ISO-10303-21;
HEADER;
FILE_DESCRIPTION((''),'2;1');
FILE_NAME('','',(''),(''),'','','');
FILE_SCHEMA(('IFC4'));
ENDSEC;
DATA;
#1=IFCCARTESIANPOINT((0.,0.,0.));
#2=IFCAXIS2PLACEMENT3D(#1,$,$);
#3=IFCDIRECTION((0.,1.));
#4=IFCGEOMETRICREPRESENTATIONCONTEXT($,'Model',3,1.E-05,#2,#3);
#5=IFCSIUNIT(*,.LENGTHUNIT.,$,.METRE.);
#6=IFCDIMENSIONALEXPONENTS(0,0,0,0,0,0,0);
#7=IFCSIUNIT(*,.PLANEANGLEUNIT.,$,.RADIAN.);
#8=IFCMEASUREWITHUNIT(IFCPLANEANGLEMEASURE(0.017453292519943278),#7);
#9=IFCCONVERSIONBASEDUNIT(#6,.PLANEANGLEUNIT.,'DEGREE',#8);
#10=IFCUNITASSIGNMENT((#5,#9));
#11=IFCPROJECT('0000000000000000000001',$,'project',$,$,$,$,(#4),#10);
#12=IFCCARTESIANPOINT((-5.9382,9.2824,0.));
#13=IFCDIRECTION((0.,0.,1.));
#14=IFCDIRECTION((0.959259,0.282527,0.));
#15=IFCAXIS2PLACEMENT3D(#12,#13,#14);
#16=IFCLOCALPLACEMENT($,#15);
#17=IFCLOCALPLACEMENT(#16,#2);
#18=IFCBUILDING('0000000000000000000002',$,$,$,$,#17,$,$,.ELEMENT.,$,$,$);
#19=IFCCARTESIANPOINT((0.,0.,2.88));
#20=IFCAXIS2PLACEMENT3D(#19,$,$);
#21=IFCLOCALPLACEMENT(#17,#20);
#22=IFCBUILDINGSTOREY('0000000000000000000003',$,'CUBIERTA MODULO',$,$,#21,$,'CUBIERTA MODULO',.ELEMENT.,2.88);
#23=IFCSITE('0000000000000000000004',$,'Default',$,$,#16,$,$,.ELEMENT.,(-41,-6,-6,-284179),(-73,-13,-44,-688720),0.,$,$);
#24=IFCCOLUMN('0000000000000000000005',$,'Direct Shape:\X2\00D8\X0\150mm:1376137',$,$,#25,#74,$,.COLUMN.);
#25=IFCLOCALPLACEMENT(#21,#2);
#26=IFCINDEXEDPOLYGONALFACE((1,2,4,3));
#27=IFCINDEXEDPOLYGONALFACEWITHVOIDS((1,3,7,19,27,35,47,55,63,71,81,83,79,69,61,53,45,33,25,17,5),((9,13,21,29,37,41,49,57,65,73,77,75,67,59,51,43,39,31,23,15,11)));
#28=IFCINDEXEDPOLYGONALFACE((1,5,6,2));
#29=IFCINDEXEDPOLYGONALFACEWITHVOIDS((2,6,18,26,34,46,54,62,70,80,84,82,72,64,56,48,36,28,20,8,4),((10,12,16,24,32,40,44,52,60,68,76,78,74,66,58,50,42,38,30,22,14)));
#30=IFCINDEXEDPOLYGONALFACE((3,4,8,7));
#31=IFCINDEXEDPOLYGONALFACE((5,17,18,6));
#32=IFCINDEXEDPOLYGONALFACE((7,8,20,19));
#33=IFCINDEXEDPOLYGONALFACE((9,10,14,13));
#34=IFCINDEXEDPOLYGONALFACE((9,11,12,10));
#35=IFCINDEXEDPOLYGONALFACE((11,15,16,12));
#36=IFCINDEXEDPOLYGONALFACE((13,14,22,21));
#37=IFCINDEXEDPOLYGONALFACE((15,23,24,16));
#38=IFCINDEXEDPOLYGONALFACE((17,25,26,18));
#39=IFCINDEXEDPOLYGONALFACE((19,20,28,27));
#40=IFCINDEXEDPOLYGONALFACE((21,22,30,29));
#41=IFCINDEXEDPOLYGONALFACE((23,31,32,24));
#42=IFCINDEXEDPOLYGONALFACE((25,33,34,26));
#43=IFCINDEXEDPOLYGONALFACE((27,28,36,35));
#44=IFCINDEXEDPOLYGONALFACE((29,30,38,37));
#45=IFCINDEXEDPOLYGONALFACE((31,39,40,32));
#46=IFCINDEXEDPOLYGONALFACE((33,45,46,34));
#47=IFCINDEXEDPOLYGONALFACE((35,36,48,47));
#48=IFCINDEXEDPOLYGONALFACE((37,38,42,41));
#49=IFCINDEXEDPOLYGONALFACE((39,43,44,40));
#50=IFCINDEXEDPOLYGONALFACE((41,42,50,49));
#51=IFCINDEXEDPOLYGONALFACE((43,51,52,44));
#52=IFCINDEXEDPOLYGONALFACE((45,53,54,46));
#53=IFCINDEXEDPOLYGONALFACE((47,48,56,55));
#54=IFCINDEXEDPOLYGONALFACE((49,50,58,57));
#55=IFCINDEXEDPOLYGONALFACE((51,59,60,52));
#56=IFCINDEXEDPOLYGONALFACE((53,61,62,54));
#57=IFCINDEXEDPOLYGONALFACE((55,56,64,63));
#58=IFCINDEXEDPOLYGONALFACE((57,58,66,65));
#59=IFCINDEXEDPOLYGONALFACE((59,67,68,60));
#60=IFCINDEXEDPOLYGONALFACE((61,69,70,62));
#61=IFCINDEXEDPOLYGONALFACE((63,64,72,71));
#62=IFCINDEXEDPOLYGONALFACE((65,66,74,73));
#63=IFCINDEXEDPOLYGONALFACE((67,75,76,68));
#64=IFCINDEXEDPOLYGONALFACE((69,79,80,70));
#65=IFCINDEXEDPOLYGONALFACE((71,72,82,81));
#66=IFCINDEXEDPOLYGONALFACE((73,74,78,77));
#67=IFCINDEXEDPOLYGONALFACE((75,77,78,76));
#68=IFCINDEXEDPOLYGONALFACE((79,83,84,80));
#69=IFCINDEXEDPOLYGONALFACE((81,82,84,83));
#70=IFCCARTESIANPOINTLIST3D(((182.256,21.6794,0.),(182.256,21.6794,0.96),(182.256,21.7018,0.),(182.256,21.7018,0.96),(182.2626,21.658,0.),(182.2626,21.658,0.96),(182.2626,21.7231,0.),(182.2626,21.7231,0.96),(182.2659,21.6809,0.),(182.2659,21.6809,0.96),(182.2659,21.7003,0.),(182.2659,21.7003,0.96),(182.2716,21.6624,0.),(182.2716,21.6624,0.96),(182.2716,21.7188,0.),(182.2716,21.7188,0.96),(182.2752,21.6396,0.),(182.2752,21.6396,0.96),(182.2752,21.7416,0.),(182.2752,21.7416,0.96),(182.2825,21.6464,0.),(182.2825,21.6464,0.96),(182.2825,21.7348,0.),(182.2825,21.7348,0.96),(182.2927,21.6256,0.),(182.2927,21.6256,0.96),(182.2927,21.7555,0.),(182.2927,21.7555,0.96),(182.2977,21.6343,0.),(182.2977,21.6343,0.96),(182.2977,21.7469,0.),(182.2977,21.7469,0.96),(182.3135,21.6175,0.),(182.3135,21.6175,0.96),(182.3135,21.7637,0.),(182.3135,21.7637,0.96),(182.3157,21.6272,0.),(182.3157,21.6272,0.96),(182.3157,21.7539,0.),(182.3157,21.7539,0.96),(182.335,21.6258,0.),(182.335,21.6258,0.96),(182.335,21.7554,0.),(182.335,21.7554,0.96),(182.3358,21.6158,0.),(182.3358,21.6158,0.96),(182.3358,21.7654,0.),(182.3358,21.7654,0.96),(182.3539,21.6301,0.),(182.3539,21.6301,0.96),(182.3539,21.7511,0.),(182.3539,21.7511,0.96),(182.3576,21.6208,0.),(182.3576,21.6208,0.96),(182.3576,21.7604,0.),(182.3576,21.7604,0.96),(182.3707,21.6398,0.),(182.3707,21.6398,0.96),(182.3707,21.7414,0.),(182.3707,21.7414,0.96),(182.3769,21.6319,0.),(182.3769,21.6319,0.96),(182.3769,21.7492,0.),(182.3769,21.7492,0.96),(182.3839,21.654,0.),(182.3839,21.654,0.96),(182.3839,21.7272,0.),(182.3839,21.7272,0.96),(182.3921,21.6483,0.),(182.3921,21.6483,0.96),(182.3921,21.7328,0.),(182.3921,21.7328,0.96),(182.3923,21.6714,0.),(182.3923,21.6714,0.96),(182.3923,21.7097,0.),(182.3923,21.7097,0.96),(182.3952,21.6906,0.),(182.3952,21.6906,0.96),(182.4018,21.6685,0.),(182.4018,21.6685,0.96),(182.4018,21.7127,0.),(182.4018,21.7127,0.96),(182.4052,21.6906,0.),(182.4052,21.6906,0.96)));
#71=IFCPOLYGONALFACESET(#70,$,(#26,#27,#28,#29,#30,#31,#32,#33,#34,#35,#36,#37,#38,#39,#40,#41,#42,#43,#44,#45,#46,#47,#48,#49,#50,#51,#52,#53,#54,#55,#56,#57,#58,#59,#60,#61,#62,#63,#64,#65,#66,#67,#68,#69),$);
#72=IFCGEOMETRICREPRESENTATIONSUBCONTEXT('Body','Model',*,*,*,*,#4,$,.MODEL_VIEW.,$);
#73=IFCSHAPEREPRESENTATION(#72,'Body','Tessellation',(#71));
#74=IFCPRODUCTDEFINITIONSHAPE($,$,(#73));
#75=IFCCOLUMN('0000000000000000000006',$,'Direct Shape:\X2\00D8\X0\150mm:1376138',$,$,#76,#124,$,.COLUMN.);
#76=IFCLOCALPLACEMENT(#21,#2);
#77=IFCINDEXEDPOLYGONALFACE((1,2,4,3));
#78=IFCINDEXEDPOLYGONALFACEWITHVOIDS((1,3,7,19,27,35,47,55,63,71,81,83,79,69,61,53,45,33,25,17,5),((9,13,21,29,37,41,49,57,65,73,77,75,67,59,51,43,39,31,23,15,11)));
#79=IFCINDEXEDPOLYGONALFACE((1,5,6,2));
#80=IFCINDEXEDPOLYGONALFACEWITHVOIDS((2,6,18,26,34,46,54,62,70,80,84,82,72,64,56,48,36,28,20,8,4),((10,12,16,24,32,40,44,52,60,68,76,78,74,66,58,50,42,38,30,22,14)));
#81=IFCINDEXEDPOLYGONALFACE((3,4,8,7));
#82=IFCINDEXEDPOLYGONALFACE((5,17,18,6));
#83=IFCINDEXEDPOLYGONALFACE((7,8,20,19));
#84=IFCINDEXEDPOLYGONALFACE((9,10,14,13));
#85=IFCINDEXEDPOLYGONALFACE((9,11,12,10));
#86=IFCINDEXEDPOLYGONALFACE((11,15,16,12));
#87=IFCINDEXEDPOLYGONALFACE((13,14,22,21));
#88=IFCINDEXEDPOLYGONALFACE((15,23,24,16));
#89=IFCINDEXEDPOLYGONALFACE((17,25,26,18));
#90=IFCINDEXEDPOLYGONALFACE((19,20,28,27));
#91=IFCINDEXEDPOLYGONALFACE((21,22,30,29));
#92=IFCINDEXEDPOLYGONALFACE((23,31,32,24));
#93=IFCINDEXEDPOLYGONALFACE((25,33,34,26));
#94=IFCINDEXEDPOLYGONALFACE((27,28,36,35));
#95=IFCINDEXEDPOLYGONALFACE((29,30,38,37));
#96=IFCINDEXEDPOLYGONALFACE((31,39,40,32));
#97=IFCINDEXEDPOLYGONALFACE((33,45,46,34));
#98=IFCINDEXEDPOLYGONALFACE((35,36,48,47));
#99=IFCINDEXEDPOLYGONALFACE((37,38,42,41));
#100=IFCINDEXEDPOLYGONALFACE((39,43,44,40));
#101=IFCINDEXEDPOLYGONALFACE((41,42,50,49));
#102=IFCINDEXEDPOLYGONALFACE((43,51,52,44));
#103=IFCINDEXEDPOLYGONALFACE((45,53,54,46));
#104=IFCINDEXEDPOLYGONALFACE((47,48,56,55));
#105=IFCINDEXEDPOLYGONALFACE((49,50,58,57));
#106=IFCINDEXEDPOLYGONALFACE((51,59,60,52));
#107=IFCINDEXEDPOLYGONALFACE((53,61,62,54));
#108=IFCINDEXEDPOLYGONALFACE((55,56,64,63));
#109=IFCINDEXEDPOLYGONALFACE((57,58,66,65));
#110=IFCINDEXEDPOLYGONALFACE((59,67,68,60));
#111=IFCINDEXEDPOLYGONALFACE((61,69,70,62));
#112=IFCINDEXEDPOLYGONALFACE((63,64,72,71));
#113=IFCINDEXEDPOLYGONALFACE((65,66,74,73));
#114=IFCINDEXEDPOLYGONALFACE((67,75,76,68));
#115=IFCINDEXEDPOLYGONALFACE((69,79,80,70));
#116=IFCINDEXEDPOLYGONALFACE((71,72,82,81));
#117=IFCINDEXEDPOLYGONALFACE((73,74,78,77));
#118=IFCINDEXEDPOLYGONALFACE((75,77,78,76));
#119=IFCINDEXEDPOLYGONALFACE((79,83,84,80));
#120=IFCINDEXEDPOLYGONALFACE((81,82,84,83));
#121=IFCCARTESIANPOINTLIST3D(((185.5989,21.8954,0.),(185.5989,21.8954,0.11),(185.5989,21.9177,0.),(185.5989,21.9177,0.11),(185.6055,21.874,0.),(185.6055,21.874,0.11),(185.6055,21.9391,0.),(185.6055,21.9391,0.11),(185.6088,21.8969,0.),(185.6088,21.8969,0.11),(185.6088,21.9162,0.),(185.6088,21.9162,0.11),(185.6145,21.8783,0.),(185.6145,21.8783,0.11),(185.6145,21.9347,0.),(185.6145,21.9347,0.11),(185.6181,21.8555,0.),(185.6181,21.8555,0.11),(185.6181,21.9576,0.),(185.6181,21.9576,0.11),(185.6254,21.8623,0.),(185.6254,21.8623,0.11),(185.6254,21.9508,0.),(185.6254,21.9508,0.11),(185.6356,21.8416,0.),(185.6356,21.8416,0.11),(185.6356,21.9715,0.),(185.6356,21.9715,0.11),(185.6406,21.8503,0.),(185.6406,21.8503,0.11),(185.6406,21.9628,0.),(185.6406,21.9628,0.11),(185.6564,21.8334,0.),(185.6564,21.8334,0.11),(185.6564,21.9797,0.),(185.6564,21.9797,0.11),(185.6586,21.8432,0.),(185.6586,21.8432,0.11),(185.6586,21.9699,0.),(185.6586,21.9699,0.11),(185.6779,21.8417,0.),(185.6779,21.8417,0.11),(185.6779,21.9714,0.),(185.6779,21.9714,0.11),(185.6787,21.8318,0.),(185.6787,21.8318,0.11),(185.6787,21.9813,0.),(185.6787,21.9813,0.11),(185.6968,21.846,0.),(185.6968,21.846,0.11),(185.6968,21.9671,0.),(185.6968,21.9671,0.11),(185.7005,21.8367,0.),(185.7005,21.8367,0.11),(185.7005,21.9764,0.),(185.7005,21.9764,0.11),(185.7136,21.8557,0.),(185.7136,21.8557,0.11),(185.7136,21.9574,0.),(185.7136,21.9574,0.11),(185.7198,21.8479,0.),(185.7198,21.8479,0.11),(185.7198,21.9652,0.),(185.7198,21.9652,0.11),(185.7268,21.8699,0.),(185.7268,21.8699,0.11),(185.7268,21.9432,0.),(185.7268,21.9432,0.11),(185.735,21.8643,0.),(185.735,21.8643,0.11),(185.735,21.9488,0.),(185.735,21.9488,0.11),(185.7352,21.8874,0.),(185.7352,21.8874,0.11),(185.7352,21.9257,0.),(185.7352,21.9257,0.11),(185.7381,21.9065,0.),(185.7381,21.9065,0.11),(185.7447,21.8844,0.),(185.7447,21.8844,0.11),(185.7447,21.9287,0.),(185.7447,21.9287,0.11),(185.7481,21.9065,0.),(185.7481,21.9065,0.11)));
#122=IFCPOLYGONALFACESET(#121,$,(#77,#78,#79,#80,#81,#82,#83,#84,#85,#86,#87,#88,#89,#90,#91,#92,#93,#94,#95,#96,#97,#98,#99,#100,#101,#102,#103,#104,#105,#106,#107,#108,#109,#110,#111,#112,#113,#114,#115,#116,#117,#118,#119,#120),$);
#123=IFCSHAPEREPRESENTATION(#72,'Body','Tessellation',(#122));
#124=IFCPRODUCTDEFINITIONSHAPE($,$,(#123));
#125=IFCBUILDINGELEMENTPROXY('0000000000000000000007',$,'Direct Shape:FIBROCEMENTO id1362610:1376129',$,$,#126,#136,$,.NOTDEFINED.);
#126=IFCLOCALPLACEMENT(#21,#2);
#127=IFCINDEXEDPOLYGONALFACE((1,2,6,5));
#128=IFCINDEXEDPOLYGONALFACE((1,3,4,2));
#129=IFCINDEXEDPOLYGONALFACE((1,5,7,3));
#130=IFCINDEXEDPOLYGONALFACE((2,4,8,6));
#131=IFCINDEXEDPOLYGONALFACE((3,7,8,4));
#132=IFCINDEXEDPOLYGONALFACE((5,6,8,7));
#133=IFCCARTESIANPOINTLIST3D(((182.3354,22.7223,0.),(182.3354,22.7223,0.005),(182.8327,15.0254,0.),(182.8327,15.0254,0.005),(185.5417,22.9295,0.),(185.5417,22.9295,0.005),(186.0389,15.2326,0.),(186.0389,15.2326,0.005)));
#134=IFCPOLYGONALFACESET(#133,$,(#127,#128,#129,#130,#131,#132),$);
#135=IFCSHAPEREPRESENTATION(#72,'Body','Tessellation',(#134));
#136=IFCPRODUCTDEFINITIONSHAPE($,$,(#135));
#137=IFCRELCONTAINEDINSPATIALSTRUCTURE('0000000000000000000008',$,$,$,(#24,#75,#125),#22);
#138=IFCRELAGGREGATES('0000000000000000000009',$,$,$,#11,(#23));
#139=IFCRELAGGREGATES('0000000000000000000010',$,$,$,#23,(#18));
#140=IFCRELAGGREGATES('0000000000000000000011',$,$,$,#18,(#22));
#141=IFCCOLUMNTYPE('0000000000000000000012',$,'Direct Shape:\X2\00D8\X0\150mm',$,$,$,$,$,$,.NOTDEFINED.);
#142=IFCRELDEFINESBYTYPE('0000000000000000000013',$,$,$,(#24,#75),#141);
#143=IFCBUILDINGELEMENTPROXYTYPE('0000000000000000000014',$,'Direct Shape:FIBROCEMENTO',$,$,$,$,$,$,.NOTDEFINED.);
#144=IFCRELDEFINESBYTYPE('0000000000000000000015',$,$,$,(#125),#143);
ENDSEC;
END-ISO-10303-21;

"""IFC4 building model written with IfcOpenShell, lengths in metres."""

from ifc_helpers import new_model, entity, si_unit, converted_unit, direction, frame, origin, origin_2d_with_axis, place, context, subcontext, project, spatial, rectangle, hollow_circle, extrude, type_object, element, save


model = new_model("IFC4")

# Units and contexts
model_context = context("Model", 3, precision=1e-05, world=origin(), true_north=direction((0.0, 1.0)))
body_context = subcontext(model_context, "Body", "Model", "MODEL_VIEW")
ifc_project = project(units=[si_unit("LENGTHUNIT", "METRE"), converted_unit("PLANEANGLEUNIT", "DEGREE", entity("IfcPlaneAngleMeasure", 0.017453292519943278), si_unit("PLANEANGLEUNIT", "RADIAN"), dimensions=[0, 0, 0, 0, 0, 0, 0])], contexts=[model_context])

# Site, building, storey
site_placement = place(None, frame((-5.9382, 9.2824, 0.0), z_axis=(0.0, 0.0, 1.0), x_axis=(0.959259, 0.282527, 0.0)))
site = spatial("IfcSite", under=ifc_project, at=site_placement, Name="Default", CompositionType="ELEMENT", RefLatitude=(-41, -6, -6, -284179), RefLongitude=(-73, -13, -44, -688720), RefElevation=0.0)
building_placement = place(site_placement, origin())
building = spatial("IfcBuilding", under=site, at=building_placement, CompositionType="ELEMENT")
storey_placement = place(building_placement, frame((0.0, 0.0, 2.88)))
storey = spatial("IfcBuildingStorey", under=building, at=storey_placement, Name="CUBIERTA MODULO", LongName="CUBIERTA MODULO", CompositionType="ELEMENT", Elevation=2.88)

# Columns
column_type = type_object("IfcColumnType", Name="Direct Shape:Ø150mm", PredefinedType="NOTDEFINED")
column_1_placement = place(storey_placement, origin())
element("IfcColumn", 1, at=column_1_placement, inside=storey, type_object=column_type, Name="Direct Shape:Ø150mm:1376137", PredefinedType="COLUMN", context=body_context, shape_type="SweptSolid", body=[
    extrude(hollow_circle(Radius=0.075, WallThickness=0.01, at=origin_2d_with_axis()), frame((182.3302, 21.6906, 0.0)), (0.0, 0.0, 1.0), 0.96),
])
column_2_placement = place(storey_placement, origin())
element("IfcColumn", 2, at=column_2_placement, inside=storey, type_object=column_type, Name="Direct Shape:Ø150mm:1376138", PredefinedType="COLUMN", context=body_context, shape_type="SweptSolid", body=[
    extrude(hollow_circle(Radius=0.075, WallThickness=0.01, at=origin_2d_with_axis()), frame((185.6731, 21.9065, 0.0)), (0.0, 0.0, 1.0), 0.11),
])

# Building element proxy
building_element_proxy_type = type_object("IfcBuildingElementProxyType", Name="Direct Shape:FIBROCEMENTO", PredefinedType="NOTDEFINED")
proxy_placement = place(storey_placement, origin())
element("IfcBuildingElementProxy", 3, at=proxy_placement, inside=storey, type_object=building_element_proxy_type, Name="Direct Shape:FIBROCEMENTO id1362610:1376129", PredefinedType="NOTDEFINED", context=body_context, shape_type="SweptSolid", body=[
    extrude(rectangle(XDim=7.7129, YDim=3.2129, at=origin_2d_with_axis()), frame((184.1872, 18.9775, 0.0), z_axis=(0.0, 0.0, 1.0), x_axis=(-0.064471, 0.99792, 0.0)), (0.0, 0.0, 1.0), 0.005),
])

save(model, "model.ifc")
